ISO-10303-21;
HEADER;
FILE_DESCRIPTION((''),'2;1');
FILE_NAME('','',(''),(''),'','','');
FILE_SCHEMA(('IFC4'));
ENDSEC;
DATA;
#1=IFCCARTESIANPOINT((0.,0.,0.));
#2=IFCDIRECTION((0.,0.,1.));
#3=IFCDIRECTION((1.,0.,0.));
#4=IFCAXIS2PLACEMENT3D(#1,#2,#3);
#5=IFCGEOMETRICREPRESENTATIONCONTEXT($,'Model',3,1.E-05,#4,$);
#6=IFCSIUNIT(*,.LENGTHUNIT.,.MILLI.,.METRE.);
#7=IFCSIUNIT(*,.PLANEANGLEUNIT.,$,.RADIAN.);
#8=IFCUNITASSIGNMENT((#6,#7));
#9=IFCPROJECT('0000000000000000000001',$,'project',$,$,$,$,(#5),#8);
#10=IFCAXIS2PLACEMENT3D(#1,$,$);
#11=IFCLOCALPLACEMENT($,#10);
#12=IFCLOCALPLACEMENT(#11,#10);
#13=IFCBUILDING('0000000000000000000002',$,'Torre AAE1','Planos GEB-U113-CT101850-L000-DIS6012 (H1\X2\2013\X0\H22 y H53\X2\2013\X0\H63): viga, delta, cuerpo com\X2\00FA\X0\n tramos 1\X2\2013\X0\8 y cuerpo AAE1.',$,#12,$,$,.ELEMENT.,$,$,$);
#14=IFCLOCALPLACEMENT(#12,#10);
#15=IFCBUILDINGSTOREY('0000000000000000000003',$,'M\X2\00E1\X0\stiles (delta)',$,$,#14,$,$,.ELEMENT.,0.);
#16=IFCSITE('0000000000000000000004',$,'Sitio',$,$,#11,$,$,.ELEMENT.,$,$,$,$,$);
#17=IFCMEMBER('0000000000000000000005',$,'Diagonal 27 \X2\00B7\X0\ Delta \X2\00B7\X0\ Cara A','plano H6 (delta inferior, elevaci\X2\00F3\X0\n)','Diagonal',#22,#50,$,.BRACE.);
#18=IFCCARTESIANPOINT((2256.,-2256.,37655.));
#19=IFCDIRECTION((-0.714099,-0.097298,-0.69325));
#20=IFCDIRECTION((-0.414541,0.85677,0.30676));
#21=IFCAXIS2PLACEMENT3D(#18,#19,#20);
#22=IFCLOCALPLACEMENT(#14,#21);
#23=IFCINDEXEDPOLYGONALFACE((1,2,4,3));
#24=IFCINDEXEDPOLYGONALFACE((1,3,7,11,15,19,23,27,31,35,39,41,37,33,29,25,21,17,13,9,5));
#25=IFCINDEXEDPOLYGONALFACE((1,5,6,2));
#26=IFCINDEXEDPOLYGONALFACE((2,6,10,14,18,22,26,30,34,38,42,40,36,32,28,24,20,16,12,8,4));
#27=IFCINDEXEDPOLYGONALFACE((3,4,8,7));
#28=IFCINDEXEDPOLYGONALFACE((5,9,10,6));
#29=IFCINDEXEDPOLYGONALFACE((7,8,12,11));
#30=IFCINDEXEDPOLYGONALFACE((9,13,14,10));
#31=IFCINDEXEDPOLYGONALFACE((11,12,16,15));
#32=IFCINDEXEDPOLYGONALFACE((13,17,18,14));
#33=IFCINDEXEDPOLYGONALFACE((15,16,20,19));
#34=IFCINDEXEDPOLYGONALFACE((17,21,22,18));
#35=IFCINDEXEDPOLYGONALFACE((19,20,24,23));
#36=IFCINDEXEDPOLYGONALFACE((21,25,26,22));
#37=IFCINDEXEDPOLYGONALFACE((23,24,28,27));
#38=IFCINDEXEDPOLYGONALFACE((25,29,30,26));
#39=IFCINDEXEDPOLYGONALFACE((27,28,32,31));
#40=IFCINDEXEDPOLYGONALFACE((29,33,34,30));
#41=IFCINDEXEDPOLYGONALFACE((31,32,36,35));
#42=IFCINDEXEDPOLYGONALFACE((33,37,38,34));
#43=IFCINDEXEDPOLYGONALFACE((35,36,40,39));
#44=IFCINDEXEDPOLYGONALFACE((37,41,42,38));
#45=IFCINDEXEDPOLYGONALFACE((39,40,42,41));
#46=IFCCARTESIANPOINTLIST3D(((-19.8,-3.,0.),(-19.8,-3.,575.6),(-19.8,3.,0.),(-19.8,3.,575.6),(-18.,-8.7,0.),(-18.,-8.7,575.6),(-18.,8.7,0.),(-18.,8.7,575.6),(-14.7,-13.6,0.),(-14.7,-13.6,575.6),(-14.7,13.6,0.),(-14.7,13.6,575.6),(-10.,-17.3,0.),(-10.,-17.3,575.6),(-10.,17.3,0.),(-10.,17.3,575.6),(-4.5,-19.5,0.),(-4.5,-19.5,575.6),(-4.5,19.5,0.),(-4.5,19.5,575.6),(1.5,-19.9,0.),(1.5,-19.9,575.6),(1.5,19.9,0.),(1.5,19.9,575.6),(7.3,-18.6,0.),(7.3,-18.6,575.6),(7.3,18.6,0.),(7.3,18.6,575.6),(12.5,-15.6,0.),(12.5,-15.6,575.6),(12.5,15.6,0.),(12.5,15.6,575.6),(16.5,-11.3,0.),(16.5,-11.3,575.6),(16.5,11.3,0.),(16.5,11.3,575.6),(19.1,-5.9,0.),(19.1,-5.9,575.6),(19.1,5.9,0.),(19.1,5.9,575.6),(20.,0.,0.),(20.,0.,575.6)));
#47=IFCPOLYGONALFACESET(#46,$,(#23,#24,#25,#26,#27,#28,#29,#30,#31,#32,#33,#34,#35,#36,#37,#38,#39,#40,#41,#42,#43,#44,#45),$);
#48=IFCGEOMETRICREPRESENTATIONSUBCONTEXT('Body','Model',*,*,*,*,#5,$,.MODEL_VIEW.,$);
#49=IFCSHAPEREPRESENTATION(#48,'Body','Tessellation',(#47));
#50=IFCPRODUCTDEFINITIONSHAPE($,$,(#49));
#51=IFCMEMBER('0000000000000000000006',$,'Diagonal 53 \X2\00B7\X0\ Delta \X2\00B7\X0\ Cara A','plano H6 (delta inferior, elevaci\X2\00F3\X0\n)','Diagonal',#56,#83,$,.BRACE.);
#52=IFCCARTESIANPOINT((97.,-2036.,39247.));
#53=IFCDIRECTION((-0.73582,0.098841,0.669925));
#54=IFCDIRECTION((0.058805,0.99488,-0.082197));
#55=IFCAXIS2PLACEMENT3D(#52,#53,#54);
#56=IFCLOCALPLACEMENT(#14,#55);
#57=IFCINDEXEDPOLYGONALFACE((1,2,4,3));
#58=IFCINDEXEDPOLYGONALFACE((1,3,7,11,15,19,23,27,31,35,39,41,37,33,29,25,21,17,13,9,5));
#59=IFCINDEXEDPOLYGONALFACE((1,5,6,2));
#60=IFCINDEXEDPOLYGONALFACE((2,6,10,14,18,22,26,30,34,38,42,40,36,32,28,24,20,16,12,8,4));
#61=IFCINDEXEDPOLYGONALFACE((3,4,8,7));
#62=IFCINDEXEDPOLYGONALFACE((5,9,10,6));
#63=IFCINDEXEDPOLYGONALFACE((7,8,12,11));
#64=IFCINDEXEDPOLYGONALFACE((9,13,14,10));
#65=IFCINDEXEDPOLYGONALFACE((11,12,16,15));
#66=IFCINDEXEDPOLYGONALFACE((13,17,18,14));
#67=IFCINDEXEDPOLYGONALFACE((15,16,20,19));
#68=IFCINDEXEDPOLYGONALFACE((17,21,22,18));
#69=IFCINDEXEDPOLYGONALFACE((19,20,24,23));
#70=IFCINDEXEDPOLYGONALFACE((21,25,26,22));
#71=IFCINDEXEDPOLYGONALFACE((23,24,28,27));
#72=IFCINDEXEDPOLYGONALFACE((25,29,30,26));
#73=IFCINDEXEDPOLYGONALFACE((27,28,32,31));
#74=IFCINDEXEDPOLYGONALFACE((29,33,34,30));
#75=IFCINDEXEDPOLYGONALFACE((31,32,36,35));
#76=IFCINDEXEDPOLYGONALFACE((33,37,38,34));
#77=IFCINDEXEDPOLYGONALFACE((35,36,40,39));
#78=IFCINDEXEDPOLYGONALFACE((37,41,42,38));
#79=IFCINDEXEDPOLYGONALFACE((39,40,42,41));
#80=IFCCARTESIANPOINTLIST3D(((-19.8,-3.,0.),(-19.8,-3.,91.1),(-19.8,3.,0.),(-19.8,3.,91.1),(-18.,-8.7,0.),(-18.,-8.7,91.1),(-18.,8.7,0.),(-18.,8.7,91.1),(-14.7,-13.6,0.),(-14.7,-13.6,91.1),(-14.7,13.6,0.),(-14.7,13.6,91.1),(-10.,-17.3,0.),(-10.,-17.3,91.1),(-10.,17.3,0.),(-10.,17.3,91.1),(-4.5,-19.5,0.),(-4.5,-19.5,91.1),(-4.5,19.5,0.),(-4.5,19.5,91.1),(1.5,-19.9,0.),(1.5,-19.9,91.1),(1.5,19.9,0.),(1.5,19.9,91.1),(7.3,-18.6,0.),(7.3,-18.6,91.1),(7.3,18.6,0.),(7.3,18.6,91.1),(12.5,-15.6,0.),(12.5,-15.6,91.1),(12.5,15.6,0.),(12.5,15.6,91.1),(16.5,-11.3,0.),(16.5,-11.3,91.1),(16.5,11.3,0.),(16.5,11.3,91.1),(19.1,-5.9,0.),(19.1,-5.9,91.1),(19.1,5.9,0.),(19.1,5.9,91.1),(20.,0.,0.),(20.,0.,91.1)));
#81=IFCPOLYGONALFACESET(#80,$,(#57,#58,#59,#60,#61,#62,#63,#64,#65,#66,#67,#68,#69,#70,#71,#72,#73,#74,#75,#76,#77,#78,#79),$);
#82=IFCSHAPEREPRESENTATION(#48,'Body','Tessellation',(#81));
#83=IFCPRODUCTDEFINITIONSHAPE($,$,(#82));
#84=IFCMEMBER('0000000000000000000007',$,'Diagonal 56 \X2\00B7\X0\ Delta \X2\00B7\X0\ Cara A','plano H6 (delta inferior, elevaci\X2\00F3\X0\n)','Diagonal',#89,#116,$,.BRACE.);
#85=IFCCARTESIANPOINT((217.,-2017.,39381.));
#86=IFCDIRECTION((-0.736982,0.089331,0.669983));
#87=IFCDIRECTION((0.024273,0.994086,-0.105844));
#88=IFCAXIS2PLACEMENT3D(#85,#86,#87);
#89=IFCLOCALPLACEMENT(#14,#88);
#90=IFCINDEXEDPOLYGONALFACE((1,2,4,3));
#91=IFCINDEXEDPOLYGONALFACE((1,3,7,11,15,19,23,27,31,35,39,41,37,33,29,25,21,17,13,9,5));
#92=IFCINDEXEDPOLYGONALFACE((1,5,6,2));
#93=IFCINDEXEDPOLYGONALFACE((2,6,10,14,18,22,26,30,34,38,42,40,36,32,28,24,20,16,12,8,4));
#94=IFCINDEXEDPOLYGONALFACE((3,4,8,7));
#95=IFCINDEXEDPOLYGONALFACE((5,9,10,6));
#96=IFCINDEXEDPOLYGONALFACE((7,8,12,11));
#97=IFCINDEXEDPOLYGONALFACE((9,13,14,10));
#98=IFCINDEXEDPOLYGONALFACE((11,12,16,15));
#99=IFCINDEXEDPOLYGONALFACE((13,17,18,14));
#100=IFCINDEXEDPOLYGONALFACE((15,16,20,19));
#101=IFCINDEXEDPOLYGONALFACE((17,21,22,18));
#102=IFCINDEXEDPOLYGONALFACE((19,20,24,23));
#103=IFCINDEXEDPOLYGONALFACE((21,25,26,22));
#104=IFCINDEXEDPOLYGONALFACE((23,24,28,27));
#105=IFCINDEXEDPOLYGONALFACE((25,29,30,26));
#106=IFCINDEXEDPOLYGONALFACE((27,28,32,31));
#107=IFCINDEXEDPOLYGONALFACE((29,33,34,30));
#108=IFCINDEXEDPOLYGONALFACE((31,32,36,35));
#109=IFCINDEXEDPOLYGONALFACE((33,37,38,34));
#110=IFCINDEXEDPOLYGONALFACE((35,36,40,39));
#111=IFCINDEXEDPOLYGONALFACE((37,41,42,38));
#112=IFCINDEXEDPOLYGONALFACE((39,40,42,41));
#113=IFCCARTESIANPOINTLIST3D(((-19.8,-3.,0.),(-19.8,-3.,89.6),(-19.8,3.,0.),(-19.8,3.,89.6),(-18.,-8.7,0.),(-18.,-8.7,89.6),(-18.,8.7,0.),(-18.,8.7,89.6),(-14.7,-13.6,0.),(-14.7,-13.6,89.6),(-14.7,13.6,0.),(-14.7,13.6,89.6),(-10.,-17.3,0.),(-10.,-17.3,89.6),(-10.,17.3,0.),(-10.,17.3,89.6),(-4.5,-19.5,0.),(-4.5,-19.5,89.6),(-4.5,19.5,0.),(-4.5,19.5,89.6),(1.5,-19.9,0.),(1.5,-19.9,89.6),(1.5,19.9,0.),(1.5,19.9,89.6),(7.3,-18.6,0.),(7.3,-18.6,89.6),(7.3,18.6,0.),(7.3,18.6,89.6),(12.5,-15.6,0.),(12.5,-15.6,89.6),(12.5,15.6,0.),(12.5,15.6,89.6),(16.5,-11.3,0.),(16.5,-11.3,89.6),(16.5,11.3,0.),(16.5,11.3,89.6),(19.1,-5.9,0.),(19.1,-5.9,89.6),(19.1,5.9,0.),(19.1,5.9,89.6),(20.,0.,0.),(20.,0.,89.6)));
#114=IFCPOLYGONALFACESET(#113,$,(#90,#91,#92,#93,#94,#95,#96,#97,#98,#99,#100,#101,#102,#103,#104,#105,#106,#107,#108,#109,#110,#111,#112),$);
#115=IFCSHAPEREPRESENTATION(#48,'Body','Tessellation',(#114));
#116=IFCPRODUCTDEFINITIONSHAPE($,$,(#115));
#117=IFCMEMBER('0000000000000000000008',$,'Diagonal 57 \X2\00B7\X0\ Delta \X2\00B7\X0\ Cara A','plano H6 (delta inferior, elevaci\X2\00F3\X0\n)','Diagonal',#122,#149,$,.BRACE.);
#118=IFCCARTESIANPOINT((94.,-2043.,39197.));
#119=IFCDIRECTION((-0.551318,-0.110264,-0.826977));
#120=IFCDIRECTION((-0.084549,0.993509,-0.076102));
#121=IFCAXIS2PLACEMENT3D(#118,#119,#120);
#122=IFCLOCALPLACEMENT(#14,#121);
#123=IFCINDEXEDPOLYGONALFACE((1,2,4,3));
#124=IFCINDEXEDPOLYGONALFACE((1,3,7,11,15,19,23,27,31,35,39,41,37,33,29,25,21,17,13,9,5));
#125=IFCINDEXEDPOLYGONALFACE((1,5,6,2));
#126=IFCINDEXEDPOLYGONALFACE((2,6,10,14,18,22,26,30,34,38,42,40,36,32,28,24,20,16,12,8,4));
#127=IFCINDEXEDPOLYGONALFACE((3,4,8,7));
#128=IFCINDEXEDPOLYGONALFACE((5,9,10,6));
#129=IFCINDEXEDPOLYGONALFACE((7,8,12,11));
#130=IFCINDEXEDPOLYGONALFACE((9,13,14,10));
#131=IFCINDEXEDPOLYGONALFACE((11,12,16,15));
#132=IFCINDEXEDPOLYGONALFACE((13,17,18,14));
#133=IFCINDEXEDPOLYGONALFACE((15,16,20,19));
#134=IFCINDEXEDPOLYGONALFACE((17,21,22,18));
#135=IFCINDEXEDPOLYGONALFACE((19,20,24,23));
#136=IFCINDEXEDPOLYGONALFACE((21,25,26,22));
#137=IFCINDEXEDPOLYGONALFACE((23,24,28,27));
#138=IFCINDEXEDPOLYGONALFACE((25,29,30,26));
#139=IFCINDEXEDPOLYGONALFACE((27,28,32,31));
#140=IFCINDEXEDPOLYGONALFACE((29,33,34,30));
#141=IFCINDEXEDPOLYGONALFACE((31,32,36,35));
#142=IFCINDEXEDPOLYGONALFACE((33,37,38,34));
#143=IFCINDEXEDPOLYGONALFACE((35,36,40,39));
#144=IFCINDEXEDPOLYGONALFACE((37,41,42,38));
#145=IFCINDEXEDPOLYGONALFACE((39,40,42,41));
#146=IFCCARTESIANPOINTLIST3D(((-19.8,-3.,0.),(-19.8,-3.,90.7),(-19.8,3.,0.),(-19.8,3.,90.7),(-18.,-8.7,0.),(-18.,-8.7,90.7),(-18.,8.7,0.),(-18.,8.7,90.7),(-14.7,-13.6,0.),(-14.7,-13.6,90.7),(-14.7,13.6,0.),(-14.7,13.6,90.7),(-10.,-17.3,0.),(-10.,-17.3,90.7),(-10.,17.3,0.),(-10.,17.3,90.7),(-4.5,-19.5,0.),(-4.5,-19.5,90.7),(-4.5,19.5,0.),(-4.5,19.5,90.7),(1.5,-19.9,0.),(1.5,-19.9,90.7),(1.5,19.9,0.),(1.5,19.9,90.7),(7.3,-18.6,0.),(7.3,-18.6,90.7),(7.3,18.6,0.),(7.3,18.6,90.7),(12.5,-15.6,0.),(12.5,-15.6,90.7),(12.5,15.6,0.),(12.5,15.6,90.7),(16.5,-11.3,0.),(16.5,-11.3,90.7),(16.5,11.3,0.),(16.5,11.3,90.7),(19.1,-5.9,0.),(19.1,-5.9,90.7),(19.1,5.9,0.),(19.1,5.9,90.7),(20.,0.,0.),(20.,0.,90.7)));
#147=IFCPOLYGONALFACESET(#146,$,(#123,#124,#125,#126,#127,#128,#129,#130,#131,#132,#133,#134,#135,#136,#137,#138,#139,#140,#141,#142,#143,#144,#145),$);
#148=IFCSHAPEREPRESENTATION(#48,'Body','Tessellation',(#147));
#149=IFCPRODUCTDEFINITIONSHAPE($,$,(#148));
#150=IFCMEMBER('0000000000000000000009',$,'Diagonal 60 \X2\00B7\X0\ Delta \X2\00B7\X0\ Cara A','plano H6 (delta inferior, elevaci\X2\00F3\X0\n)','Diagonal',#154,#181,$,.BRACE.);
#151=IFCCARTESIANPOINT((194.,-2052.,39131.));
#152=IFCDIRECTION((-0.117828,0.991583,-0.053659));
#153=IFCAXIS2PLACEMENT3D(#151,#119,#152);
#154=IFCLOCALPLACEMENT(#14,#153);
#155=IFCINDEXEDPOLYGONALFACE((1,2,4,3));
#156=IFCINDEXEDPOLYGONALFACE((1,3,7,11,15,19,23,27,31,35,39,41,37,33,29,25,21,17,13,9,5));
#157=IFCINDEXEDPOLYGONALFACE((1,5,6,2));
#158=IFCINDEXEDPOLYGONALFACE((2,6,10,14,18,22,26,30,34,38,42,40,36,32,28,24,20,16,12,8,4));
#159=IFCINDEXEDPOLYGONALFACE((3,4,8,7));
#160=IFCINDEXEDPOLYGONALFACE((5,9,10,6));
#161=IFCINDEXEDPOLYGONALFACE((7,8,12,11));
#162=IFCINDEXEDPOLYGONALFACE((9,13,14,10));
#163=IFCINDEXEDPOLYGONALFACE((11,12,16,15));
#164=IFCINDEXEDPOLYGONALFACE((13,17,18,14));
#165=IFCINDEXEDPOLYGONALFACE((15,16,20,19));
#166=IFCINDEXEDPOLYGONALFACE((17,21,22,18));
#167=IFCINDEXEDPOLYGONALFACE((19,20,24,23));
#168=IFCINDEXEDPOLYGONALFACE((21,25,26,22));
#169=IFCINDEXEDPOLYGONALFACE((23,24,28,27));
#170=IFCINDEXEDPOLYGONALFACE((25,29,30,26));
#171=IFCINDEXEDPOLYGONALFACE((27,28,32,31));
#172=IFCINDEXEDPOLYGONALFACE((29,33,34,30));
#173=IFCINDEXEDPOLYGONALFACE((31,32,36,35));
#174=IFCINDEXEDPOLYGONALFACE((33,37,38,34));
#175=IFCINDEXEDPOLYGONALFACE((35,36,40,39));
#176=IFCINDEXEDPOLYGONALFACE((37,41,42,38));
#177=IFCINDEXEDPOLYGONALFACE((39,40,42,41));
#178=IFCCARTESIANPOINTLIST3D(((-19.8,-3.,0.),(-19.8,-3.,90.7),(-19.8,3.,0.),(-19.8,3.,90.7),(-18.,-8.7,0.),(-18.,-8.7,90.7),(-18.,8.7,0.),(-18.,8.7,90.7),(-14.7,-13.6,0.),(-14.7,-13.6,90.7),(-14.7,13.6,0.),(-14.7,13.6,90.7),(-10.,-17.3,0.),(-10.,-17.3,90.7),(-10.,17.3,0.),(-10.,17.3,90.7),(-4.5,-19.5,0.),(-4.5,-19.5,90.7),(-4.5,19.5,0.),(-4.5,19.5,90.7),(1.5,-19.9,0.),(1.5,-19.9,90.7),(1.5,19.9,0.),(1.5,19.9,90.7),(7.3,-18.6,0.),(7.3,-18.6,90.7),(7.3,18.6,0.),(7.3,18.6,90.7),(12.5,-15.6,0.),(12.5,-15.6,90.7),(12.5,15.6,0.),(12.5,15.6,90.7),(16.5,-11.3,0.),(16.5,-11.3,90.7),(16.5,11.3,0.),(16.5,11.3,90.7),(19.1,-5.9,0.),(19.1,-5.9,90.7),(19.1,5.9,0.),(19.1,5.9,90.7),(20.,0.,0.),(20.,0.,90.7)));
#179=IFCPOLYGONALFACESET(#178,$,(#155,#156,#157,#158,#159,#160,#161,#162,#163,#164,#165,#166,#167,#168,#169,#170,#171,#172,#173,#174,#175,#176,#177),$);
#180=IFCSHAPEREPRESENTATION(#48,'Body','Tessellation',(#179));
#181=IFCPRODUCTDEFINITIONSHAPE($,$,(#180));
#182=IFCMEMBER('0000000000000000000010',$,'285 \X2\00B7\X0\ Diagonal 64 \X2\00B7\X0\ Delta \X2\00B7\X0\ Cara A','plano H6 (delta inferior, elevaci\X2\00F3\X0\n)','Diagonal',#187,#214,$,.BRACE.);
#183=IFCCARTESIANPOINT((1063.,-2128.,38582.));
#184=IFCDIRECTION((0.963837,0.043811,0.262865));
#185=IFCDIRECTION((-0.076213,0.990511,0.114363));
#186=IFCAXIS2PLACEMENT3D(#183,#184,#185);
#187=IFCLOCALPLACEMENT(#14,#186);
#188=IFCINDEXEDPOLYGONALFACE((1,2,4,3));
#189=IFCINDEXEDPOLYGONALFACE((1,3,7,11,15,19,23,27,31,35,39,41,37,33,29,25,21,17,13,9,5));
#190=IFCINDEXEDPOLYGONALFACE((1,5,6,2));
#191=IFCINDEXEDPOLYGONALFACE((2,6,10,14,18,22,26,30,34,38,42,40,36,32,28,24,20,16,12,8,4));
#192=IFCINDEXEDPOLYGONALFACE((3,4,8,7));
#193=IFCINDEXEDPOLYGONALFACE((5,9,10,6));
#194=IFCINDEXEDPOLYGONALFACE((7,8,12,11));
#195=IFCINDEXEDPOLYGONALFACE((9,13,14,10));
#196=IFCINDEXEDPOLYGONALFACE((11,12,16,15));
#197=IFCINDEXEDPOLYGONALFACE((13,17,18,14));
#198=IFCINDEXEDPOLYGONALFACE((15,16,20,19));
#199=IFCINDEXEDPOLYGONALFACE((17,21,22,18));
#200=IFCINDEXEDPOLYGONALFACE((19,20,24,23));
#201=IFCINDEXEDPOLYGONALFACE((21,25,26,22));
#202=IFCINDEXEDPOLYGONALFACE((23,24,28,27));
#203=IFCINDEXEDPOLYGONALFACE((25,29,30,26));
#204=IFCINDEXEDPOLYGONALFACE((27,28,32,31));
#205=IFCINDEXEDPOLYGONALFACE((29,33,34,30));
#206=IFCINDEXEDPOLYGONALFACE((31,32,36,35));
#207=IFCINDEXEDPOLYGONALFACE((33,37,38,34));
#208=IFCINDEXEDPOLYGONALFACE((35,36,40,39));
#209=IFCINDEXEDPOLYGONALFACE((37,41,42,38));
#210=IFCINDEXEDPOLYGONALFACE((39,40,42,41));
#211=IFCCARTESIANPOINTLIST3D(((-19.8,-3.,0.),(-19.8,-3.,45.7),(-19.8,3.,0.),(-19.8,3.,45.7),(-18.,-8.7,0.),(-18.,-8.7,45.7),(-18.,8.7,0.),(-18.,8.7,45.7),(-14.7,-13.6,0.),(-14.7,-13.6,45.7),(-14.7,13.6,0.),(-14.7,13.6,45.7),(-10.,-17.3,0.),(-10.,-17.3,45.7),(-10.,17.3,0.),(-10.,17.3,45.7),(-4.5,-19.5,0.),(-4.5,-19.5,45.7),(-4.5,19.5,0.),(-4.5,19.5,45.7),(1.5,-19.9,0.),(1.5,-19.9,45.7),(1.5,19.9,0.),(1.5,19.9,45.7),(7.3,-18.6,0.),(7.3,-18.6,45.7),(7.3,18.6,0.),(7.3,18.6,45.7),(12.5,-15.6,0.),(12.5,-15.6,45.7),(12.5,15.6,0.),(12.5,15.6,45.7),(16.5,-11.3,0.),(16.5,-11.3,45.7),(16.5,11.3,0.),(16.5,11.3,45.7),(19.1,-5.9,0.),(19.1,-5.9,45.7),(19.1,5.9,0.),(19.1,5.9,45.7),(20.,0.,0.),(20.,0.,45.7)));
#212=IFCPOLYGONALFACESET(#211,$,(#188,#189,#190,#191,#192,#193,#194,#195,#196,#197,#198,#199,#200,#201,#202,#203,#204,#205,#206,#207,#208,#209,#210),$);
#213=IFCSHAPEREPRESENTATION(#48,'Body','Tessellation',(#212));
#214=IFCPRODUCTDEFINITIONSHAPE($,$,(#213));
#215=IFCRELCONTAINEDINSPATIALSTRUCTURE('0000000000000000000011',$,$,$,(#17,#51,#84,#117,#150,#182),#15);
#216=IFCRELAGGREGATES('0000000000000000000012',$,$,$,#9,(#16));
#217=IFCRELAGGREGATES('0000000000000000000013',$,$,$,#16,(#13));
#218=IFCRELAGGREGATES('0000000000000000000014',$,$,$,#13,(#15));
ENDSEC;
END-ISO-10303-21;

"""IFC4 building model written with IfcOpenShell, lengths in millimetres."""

from ifc_helpers import new_model, si_unit, frame, origin, origin_with_axes, place, context, subcontext, project, spatial, circle, extrude, element, save


model = new_model("IFC4")

# Units and contexts
model_context = context("Model", 3, precision=1e-05, world=origin_with_axes())
body_context = subcontext(model_context, "Body", "Model", "MODEL_VIEW")
ifc_project = project(units=[si_unit("LENGTHUNIT", "METRE", prefix="MILLI"), si_unit("PLANEANGLEUNIT", "RADIAN")], contexts=[model_context])

# Site, building, storey
site_placement = place(None, origin())
site = spatial("IfcSite", under=ifc_project, at=site_placement, Name="Sitio", CompositionType="ELEMENT")
building_placement = place(site_placement, origin())
building = spatial("IfcBuilding", under=site, at=building_placement, Name="Torre AAE1", Description="Planos GEB-U113-CT101850-L000-DIS6012 (H1–H22 y H53–H63): viga, delta, cuerpo común tramos 1–8 y cuerpo AAE1.", CompositionType="ELEMENT")
storey_placement = place(building_placement, origin())
storey = spatial("IfcBuildingStorey", under=building, at=storey_placement, Name="Mástiles (delta)", CompositionType="ELEMENT", Elevation=0.0)

# Members
member_1_placement = place(storey_placement, frame((2256.0, -2256.0, 37655.0), z_axis=(-0.714099, -0.097298, -0.69325), x_axis=(-0.414541, 0.85677, 0.30676)))
element("IfcMember", 1, at=member_1_placement, inside=storey, Name="Diagonal 27 · Delta · Cara A", Description="plano H6 (delta inferior, elevación)", ObjectType="Diagonal", PredefinedType="BRACE", context=body_context, shape_type="SweptSolid", body=[
    extrude(circle(Radius=20.0), None, (0.0, 0.0, 1.0), 575.6),
])
member_2_placement = place(storey_placement, frame((97.0, -2036.0, 39247.0), z_axis=(-0.73582, 0.098841, 0.669925), x_axis=(0.058805, 0.99488, -0.082197)))
element("IfcMember", 2, at=member_2_placement, inside=storey, Name="Diagonal 53 · Delta · Cara A", Description="plano H6 (delta inferior, elevación)", ObjectType="Diagonal", PredefinedType="BRACE", context=body_context, shape_type="SweptSolid", body=[
    extrude(circle(Radius=20.0), None, (0.0, 0.0, 1.0), 91.1),
])
member_3_placement = place(storey_placement, frame((217.0, -2017.0, 39381.0), z_axis=(-0.736982, 0.089331, 0.669983), x_axis=(0.024273, 0.994086, -0.105844)))
element("IfcMember", 3, at=member_3_placement, inside=storey, Name="Diagonal 56 · Delta · Cara A", Description="plano H6 (delta inferior, elevación)", ObjectType="Diagonal", PredefinedType="BRACE", context=body_context, shape_type="SweptSolid", body=[
    extrude(circle(Radius=20.0), None, (0.0, 0.0, 1.0), 89.6),
])
member_4_placement = place(storey_placement, frame((94.0, -2043.0, 39197.0), z_axis=(-0.551318, -0.110264, -0.826977), x_axis=(-0.084549, 0.993509, -0.076102)))
element("IfcMember", 4, at=member_4_placement, inside=storey, Name="Diagonal 57 · Delta · Cara A", Description="plano H6 (delta inferior, elevación)", ObjectType="Diagonal", PredefinedType="BRACE", context=body_context, shape_type="SweptSolid", body=[
    extrude(circle(Radius=20.0), None, (0.0, 0.0, 1.0), 90.7),
])
member_5_placement = place(storey_placement, frame((194.0, -2052.0, 39131.0), z_axis=(-0.551318, -0.110264, -0.826977), x_axis=(-0.117828, 0.991583, -0.053659)))
element("IfcMember", 5, at=member_5_placement, inside=storey, Name="Diagonal 60 · Delta · Cara A", Description="plano H6 (delta inferior, elevación)", ObjectType="Diagonal", PredefinedType="BRACE", context=body_context, shape_type="SweptSolid", body=[
    extrude(circle(Radius=20.0), None, (0.0, 0.0, 1.0), 90.7),
])
member_6_placement = place(storey_placement, frame((1063.0, -2128.0, 38582.0), z_axis=(0.963837, 0.043811, 0.262865), x_axis=(-0.076213, 0.990511, 0.114363)))
element("IfcMember", 6, at=member_6_placement, inside=storey, Name="285 · Diagonal 64 · Delta · Cara A", Description="plano H6 (delta inferior, elevación)", ObjectType="Diagonal", PredefinedType="BRACE", context=body_context, shape_type="SweptSolid", body=[
    extrude(circle(Radius=20.0), None, (0.0, 0.0, 1.0), 45.7),
])

save(model, "model.ifc")
